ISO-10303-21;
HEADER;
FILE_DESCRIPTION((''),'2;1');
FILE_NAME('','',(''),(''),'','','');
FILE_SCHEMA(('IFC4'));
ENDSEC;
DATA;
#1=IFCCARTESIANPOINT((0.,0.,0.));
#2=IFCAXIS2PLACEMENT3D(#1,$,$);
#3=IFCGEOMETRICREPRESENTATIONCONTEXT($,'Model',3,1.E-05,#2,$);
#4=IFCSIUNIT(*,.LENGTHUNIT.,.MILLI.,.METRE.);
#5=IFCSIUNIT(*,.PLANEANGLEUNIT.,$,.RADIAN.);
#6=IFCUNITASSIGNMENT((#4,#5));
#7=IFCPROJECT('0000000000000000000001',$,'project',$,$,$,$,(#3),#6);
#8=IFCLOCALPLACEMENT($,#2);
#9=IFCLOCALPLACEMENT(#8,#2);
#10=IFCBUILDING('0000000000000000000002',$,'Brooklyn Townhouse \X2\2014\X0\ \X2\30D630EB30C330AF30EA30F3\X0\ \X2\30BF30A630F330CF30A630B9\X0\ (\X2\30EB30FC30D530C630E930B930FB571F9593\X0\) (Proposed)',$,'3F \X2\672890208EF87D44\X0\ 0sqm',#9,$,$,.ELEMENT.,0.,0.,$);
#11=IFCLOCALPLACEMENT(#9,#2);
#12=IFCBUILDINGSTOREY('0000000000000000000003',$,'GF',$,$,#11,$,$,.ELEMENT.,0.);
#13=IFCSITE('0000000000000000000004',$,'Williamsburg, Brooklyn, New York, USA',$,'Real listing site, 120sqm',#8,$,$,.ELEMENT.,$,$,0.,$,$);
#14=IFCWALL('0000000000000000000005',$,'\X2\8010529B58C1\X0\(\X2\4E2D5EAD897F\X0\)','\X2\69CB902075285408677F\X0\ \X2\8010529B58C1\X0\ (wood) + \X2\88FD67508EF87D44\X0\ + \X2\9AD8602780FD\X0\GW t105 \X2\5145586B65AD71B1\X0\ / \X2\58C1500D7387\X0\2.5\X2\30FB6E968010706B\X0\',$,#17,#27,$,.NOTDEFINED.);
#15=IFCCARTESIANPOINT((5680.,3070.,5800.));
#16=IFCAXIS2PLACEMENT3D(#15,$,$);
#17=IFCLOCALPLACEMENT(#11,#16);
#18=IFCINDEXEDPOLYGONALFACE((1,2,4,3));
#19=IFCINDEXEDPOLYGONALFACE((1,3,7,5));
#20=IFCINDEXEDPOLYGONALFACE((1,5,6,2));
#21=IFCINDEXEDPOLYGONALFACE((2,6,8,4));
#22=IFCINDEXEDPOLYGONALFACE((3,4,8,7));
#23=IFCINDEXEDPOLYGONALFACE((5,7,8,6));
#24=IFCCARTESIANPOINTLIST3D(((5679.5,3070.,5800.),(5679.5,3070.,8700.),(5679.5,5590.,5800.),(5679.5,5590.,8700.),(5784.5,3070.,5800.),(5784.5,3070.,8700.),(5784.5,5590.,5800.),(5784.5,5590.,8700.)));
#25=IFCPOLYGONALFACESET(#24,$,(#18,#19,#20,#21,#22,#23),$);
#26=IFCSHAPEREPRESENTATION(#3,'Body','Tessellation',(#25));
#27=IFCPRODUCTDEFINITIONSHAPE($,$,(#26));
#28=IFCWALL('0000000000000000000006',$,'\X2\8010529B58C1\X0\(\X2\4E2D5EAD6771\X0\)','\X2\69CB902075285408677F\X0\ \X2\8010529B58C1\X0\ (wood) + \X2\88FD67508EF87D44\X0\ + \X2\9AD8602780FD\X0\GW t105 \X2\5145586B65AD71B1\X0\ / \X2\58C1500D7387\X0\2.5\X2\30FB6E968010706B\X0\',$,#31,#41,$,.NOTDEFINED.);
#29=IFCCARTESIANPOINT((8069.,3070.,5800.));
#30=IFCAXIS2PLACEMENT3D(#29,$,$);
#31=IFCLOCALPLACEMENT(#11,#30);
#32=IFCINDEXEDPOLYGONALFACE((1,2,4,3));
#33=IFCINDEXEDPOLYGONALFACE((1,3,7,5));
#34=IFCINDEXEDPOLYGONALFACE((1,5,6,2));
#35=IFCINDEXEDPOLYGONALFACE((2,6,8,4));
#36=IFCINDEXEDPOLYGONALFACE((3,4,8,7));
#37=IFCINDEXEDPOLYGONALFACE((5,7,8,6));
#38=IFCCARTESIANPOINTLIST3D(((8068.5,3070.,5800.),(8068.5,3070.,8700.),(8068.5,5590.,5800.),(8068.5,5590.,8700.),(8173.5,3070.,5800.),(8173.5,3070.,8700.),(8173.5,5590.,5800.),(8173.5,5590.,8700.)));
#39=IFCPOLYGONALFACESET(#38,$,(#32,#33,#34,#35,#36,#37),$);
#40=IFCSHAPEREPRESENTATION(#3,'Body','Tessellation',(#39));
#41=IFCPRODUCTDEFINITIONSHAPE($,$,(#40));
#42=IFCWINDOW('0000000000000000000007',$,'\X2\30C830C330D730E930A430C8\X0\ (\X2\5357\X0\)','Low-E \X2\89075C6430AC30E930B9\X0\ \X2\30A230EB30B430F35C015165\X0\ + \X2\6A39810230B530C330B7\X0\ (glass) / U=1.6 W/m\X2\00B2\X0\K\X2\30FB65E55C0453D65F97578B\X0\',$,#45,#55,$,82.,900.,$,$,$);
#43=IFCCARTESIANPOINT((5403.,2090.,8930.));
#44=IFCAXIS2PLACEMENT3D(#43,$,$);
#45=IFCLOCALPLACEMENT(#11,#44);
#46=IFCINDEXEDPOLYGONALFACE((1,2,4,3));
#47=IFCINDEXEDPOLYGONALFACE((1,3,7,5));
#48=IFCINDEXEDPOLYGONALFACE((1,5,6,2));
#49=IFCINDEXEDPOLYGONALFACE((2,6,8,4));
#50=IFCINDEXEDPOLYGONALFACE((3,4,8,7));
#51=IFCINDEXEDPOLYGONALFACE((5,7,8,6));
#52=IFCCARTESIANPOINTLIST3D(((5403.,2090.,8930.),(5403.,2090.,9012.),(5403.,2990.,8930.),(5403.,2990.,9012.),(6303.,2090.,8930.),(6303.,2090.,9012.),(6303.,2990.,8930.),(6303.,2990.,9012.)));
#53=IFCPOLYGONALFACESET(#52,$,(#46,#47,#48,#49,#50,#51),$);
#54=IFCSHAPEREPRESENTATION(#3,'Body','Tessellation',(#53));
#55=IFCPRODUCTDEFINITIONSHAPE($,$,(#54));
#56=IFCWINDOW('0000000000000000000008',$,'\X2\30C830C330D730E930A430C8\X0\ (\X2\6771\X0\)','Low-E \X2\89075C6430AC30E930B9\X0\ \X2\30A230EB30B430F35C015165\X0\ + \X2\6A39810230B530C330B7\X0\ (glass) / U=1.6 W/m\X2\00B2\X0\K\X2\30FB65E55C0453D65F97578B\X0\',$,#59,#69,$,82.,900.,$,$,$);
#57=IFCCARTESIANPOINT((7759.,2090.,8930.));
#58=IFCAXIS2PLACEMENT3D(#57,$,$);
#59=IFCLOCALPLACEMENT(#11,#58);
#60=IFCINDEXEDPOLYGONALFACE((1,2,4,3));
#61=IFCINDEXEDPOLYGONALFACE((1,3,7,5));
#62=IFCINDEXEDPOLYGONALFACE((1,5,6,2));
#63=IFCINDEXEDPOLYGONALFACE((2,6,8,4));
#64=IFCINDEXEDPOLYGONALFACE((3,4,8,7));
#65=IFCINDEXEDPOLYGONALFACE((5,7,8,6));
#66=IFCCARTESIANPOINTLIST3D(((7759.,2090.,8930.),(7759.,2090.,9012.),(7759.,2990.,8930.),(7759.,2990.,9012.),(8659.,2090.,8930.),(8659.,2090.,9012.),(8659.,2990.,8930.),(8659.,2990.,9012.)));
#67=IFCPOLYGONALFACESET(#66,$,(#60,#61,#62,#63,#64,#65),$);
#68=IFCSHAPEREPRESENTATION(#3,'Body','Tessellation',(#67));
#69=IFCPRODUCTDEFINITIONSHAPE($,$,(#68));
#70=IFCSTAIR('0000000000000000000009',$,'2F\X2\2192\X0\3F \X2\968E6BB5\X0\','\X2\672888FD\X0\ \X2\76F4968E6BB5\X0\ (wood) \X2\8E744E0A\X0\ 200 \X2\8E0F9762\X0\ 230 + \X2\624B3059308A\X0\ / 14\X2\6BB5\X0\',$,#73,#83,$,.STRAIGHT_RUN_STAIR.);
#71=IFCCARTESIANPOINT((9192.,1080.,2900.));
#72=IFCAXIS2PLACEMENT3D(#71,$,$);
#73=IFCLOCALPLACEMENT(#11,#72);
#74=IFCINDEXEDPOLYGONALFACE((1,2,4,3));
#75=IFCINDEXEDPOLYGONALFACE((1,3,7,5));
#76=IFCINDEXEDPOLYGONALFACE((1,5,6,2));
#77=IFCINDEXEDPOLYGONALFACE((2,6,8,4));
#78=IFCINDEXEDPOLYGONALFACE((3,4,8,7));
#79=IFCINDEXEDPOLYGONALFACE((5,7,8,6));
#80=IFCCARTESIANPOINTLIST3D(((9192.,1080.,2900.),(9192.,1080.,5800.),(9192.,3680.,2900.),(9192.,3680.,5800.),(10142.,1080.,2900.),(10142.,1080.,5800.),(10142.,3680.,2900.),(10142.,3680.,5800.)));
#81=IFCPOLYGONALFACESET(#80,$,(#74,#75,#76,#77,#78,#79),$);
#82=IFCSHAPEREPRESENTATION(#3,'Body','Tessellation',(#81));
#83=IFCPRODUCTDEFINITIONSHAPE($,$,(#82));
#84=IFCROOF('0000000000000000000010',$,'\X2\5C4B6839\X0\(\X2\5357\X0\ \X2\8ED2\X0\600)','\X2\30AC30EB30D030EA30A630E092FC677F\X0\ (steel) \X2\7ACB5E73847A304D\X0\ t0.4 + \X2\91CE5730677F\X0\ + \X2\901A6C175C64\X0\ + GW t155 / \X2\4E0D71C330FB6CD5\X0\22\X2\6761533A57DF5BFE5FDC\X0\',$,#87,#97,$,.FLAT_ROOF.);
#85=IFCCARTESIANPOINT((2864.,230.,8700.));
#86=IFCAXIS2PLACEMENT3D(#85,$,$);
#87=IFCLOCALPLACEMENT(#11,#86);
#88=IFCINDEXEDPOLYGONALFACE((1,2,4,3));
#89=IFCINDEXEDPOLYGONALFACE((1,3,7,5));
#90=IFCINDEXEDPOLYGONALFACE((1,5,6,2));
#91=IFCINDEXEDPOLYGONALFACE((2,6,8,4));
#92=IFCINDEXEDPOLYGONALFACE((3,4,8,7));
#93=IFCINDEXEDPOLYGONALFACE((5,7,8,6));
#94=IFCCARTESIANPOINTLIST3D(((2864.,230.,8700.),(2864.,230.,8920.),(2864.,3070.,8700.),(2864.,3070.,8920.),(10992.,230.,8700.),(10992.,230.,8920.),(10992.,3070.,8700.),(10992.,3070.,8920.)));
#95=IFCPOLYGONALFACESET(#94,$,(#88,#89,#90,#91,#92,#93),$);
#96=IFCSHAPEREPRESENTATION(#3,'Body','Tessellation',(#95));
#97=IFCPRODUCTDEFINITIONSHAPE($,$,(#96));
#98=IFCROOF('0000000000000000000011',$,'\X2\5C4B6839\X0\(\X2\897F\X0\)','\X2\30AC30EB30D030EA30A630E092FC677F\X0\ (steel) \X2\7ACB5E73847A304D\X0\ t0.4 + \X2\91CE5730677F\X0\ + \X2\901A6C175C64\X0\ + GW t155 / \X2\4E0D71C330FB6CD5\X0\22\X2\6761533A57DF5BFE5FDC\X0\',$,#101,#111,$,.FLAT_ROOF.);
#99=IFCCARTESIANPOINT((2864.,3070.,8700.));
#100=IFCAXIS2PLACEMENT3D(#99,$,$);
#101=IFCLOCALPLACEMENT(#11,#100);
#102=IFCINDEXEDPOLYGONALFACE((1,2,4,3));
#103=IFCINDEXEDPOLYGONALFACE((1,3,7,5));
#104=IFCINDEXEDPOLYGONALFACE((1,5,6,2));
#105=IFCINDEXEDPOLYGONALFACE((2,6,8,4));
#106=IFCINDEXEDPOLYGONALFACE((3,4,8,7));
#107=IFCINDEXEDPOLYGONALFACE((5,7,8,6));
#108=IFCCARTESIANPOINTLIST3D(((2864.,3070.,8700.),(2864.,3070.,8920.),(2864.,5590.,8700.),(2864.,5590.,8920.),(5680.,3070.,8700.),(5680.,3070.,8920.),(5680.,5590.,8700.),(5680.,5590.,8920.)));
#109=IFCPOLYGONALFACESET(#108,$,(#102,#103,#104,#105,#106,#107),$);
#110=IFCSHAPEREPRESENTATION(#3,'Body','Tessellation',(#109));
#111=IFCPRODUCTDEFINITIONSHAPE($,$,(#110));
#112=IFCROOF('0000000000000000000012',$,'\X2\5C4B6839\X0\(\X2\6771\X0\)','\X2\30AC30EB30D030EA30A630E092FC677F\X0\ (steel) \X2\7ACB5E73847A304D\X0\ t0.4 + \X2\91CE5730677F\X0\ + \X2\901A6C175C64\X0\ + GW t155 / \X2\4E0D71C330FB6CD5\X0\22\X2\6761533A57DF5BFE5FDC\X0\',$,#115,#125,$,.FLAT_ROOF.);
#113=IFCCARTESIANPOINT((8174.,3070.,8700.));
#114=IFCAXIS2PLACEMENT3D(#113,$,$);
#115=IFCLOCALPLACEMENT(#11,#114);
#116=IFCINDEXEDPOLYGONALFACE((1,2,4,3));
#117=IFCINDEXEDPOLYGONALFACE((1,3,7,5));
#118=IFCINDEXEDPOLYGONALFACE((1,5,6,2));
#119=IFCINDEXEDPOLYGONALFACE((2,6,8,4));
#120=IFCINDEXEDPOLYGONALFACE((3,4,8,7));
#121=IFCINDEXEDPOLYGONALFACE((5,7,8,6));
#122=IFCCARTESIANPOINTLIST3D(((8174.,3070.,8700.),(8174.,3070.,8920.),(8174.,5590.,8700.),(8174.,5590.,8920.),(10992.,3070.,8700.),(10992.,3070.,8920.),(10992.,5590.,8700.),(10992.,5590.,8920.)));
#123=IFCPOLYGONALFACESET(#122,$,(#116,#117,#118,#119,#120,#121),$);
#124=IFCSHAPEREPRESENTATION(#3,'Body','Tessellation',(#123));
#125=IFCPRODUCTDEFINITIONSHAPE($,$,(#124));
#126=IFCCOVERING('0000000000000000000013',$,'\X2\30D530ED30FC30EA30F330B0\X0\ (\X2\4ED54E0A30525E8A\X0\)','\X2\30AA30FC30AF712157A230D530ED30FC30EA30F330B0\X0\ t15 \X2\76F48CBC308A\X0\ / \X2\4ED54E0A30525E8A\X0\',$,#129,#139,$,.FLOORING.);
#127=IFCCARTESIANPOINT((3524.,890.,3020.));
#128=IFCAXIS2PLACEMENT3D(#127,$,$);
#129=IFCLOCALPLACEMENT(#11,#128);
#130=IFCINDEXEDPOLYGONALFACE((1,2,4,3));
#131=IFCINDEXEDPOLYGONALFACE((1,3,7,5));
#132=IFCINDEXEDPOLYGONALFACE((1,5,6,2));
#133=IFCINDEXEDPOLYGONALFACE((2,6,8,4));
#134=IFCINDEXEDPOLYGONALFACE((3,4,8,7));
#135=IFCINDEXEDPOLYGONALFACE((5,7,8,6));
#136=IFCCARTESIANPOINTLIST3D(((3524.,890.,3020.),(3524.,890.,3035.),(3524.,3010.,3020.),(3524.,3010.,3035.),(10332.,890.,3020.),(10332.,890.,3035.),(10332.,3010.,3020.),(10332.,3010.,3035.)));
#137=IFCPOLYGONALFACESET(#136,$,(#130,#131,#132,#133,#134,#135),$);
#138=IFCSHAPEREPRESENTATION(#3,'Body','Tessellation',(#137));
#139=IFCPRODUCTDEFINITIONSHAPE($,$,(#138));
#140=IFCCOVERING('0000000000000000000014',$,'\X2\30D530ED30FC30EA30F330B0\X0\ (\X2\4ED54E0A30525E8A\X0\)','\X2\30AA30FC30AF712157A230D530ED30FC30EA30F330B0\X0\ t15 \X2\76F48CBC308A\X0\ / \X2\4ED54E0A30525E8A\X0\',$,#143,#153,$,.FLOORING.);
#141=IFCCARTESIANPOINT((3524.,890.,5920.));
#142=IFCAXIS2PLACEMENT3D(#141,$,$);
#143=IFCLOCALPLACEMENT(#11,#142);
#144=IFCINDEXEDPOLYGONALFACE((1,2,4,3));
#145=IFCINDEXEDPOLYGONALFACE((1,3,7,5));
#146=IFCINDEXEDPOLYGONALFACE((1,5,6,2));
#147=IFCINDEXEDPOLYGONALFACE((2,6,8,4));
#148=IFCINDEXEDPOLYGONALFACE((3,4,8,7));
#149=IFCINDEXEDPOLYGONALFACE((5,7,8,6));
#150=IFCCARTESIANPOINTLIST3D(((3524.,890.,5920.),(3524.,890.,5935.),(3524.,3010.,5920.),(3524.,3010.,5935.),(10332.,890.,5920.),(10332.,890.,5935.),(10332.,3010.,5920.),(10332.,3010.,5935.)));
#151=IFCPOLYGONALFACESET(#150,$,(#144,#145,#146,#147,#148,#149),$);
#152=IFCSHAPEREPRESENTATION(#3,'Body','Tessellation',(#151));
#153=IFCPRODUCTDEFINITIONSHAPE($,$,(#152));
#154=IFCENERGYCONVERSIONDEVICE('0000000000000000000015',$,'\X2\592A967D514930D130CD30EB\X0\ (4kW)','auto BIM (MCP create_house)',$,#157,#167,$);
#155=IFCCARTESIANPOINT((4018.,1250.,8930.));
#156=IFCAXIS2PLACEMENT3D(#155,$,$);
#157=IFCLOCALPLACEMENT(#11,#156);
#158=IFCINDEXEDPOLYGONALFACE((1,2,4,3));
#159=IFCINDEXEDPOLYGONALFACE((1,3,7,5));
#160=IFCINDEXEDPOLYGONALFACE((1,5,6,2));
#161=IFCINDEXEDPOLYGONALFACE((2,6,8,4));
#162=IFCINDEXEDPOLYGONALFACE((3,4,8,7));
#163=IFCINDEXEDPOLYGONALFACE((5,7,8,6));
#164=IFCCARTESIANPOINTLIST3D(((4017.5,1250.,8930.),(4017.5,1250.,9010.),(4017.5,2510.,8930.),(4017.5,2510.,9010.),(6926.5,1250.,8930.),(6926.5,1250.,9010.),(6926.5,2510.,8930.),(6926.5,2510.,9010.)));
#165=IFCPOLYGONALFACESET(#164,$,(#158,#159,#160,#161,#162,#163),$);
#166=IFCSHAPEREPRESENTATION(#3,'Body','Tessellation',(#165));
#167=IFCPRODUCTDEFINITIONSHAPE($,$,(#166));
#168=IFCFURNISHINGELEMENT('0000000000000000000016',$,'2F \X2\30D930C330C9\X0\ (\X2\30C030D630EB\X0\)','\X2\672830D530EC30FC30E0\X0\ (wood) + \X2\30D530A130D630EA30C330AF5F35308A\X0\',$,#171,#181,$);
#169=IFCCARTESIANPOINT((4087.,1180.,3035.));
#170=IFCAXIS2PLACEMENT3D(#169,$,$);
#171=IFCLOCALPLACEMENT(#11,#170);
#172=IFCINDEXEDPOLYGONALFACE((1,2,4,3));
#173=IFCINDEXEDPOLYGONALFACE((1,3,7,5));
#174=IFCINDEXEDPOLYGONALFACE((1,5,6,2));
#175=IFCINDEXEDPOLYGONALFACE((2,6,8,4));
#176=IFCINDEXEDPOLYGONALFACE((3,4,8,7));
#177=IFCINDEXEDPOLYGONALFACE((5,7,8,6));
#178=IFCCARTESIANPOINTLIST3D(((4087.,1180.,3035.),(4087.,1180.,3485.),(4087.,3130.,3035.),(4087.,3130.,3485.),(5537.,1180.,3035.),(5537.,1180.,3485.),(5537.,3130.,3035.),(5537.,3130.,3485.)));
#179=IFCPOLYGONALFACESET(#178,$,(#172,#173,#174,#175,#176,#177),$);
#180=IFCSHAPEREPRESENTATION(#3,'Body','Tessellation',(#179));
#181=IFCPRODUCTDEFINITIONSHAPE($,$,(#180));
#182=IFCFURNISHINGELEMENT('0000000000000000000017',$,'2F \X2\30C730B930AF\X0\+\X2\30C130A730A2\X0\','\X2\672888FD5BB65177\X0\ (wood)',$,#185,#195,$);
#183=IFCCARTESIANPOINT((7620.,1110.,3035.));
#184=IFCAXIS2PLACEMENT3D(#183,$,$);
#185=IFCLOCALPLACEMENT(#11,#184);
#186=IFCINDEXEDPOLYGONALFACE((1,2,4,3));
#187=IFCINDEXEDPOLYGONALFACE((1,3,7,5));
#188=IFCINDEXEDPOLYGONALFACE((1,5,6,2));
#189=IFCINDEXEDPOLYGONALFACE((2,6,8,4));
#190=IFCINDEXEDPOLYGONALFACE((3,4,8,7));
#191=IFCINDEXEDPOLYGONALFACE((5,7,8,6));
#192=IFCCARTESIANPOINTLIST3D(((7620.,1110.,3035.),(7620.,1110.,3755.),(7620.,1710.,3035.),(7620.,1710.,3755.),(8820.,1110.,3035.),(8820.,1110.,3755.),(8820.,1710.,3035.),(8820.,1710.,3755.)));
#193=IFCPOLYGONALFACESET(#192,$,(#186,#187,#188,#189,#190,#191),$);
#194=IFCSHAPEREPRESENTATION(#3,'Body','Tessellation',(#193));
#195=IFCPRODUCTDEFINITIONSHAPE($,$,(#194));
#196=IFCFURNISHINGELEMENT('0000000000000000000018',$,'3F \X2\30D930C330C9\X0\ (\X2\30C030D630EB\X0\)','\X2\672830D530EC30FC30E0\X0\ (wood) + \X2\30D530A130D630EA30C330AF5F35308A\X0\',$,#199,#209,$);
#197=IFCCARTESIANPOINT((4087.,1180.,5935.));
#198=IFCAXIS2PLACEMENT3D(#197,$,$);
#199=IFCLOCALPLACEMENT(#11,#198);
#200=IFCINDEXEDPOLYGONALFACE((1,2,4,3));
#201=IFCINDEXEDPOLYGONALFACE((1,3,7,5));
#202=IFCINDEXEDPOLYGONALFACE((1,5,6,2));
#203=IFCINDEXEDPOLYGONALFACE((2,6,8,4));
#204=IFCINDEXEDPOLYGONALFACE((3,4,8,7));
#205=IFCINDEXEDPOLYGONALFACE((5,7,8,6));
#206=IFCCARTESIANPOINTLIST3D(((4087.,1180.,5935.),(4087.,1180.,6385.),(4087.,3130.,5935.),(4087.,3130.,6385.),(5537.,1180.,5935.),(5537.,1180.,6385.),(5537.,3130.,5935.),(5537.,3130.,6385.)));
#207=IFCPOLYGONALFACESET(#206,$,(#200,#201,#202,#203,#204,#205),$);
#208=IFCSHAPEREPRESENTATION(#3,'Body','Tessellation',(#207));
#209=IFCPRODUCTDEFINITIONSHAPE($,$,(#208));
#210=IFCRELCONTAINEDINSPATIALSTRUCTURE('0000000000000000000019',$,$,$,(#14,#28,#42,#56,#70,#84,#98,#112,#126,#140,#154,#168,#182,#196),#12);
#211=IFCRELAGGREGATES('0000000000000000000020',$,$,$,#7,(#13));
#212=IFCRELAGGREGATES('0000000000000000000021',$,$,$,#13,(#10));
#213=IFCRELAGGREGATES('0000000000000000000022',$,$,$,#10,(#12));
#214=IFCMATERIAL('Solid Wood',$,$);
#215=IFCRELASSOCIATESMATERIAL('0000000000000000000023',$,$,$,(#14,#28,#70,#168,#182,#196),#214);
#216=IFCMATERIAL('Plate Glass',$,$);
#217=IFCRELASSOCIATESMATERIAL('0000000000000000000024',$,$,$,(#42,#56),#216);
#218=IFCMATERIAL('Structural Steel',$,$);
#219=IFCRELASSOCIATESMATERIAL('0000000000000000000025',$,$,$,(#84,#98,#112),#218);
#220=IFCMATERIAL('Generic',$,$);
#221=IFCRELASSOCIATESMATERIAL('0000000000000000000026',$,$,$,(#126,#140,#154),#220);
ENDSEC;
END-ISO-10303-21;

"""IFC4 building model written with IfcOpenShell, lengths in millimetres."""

from ifc_helpers import new_model, si_unit, frame, frame_2d, origin, place, context, project, spatial, rectangle, extrude, material, element, save


model = new_model("IFC4")

# Units and contexts
model_context = context("Model", 3, precision=1e-05, world=origin())
ifc_project = project(units=[si_unit("LENGTHUNIT", "METRE", prefix="MILLI"), si_unit("PLANEANGLEUNIT", "RADIAN")], contexts=[model_context])

# Site, building, storey
site_placement = place(None, origin())
site = spatial("IfcSite", under=ifc_project, at=site_placement, Name="Williamsburg, Brooklyn, New York, USA", ObjectType="Real listing site, 120sqm", CompositionType="ELEMENT", RefElevation=0.0)
building_placement = place(site_placement, origin())
building = spatial("IfcBuilding", under=site, at=building_placement, Name="Brooklyn Townhouse — ブルックリン タウンハウス (ルーフテラス・土間) (Proposed)", ObjectType="3F 木造軸組 0sqm", CompositionType="ELEMENT", ElevationOfRefHeight=0.0, ElevationOfTerrain=0.0)
storey_placement = place(building_placement, origin())
storey = spatial("IfcBuildingStorey", under=building, at=storey_placement, Name="GF", CompositionType="ELEMENT", Elevation=0.0)

# Shared definitions
ifc_material_1 = material(Name="Solid Wood")

# Shared definitions
ifc_material_2 = material(Name="Plate Glass")

# Walls
wall_1_placement = place(storey_placement, frame((5680.0, 3070.0, 5800.0)))
element("IfcWall", 1, at=wall_1_placement, inside=storey, material=ifc_material_1, Name="耐力壁(中庭西)", Description="構造用合板 耐力壁 (wood) + 製材軸組 + 高性能GW t105 充填断熱 / 壁倍率2.5・準耐火", PredefinedType="NOTDEFINED", context=model_context, shape_type="SweptSolid", body=[
    extrude(rectangle(XDim=105.0, YDim=2520.0, at=frame_2d((52.0, 1260.0))), frame((5680.0, 3070.0, 5800.0)), (0.0, 0.0, 1.0), 2900.0),
])
wall_2_placement = place(storey_placement, frame((8069.0, 3070.0, 5800.0)))
element("IfcWall", 2, at=wall_2_placement, inside=storey, material=ifc_material_1, Name="耐力壁(中庭東)", Description="構造用合板 耐力壁 (wood) + 製材軸組 + 高性能GW t105 充填断熱 / 壁倍率2.5・準耐火", PredefinedType="NOTDEFINED", context=model_context, shape_type="SweptSolid", body=[
    extrude(rectangle(XDim=105.0, YDim=2520.0, at=frame_2d((52.0, 1260.0))), frame((8069.0, 3070.0, 5800.0)), (0.0, 0.0, 1.0), 2900.0),
])

# Windows
window_1_placement = place(storey_placement, frame((5403.0, 2090.0, 8930.0)))
element("IfcWindow", 3, at=window_1_placement, inside=storey, material=ifc_material_2, Name="トップライト (南)", Description="Low-E 複層ガラス アルゴン封入 + 樹脂サッシ (glass) / U=1.6 W/m²K・日射取得型", OverallHeight=82.0, OverallWidth=900.0, context=model_context, shape_type="SweptSolid", body=[
    extrude(rectangle(XDim=900.0, YDim=900.0, at=frame_2d((450.0, 450.0))), frame((5403.0, 2090.0, 8930.0)), (0.0, 0.0, 1.0), 82.0),
])
window_2_placement = place(storey_placement, frame((7759.0, 2090.0, 8930.0)))
element("IfcWindow", 4, at=window_2_placement, inside=storey, material=ifc_material_2, Name="トップライト (東)", Description="Low-E 複層ガラス アルゴン封入 + 樹脂サッシ (glass) / U=1.6 W/m²K・日射取得型", OverallHeight=82.0, OverallWidth=900.0, context=model_context, shape_type="SweptSolid", body=[
    extrude(rectangle(XDim=900.0, YDim=900.0, at=frame_2d((450.0, 450.0))), frame((7759.0, 2090.0, 8930.0)), (0.0, 0.0, 1.0), 82.0),
])

# Stair
stair_placement = place(storey_placement, frame((9192.0, 1080.0, 2900.0)))
element("IfcStair", 5, at=stair_placement, inside=storey, material=ifc_material_1, Name="2F→3F 階段", Description="木製 直階段 (wood) 蹴上 200 踏面 230 + 手すり / 14段", PredefinedType="STRAIGHT_RUN_STAIR", context=model_context, shape_type="SweptSolid", body=[
    extrude(rectangle(XDim=950.0, YDim=2600.0, at=frame_2d((475.0, 1300.0))), frame((9192.0, 1080.0, 2900.0)), (0.0, 0.0, 1.0), 2900.0),
])

# Roofs
ifc_material_3 = material(Name="Structural Steel")
roof_1_placement = place(storey_placement, frame((2864.0, 230.0, 8700.0)))
element("IfcRoof", 6, at=roof_1_placement, inside=storey, material=ifc_material_3, Name="屋根(南 軒600)", Description="ガルバリウム鋼板 (steel) 立平葺き t0.4 + 野地板 + 通気層 + GW t155 / 不燃・法22条区域対応", PredefinedType="FLAT_ROOF", context=model_context, shape_type="SweptSolid", body=[
    extrude(rectangle(XDim=8128.0, YDim=2840.0, at=frame_2d((4064.0, 1420.0))), frame((2864.0, 230.0, 8700.0)), (0.0, 0.0, 1.0), 220.0),
])
roof_2_placement = place(storey_placement, frame((2864.0, 3070.0, 8700.0)))
element("IfcRoof", 7, at=roof_2_placement, inside=storey, material=ifc_material_3, Name="屋根(西)", Description="ガルバリウム鋼板 (steel) 立平葺き t0.4 + 野地板 + 通気層 + GW t155 / 不燃・法22条区域対応", PredefinedType="FLAT_ROOF", context=model_context, shape_type="SweptSolid", body=[
    extrude(rectangle(XDim=2816.0, YDim=2520.0, at=frame_2d((1408.0, 1260.0))), frame((2864.0, 3070.0, 8700.0)), (0.0, 0.0, 1.0), 220.0),
])
roof_3_placement = place(storey_placement, frame((8174.0, 3070.0, 8700.0)))
element("IfcRoof", 8, at=roof_3_placement, inside=storey, material=ifc_material_3, Name="屋根(東)", Description="ガルバリウム鋼板 (steel) 立平葺き t0.4 + 野地板 + 通気層 + GW t155 / 不燃・法22条区域対応", PredefinedType="FLAT_ROOF", context=model_context, shape_type="SweptSolid", body=[
    extrude(rectangle(XDim=2818.0, YDim=2520.0, at=frame_2d((1409.0, 1260.0))), frame((8174.0, 3070.0, 8700.0)), (0.0, 0.0, 1.0), 220.0),
])

# Coverings
ifc_material_4 = material(Name="Generic")
covering_1_placement = place(storey_placement, frame((3524.0, 890.0, 3020.0)))
element("IfcCovering", 9, at=covering_1_placement, inside=storey, material=ifc_material_4, Name="フローリング (仕上げ床)", Description="オーク無垢フローリング t15 直貼り / 仕上げ床", PredefinedType="FLOORING", context=model_context, shape_type="SweptSolid", body=[
    extrude(rectangle(XDim=6808.0, YDim=2120.0, at=frame_2d((3404.0, 1060.0))), frame((3524.0, 890.0, 3020.0)), (0.0, 0.0, 1.0), 15.0),
])
covering_2_placement = place(storey_placement, frame((3524.0, 890.0, 5920.0)))
element("IfcCovering", 10, at=covering_2_placement, inside=storey, material=ifc_material_4, Name="フローリング (仕上げ床)", Description="オーク無垢フローリング t15 直貼り / 仕上げ床", PredefinedType="FLOORING", context=model_context, shape_type="SweptSolid", body=[
    extrude(rectangle(XDim=6808.0, YDim=2120.0, at=frame_2d((3404.0, 1060.0))), frame((3524.0, 890.0, 5920.0)), (0.0, 0.0, 1.0), 15.0),
])

# Energy conversion device
energy_conversion_device_placement = place(storey_placement, frame((4018.0, 1250.0, 8930.0)))
element("IfcEnergyConversionDevice", 11, at=energy_conversion_device_placement, inside=storey, material=ifc_material_4, Name="太陽光パネル (4kW)", Description="auto BIM (MCP create_house)", context=model_context, shape_type="SweptSolid", body=[
    extrude(rectangle(XDim=2909.0, YDim=1260.0, at=frame_2d((1454.0, 630.0))), frame((4018.0, 1250.0, 8930.0)), (0.0, 0.0, 1.0), 80.0),
])

# Furnishing elements
furnishing_1_placement = place(storey_placement, frame((4087.0, 1180.0, 3035.0)))
element("IfcFurnishingElement", 12, at=furnishing_1_placement, inside=storey, material=ifc_material_1, Name="2F ベッド (ダブル)", Description="木フレーム (wood) + ファブリック張り", context=model_context, shape_type="SweptSolid", body=[
    extrude(rectangle(XDim=1450.0, YDim=1950.0, at=frame_2d((725.0, 975.0))), frame((4087.0, 1180.0, 3035.0)), (0.0, 0.0, 1.0), 450.0),
])
furnishing_2_placement = place(storey_placement, frame((7620.0, 1110.0, 3035.0)))
element("IfcFurnishingElement", 13, at=furnishing_2_placement, inside=storey, material=ifc_material_1, Name="2F デスク+チェア", Description="木製家具 (wood)", context=model_context, shape_type="SweptSolid", body=[
    extrude(rectangle(XDim=1200.0, YDim=600.0, at=frame_2d((600.0, 300.0))), frame((7620.0, 1110.0, 3035.0)), (0.0, 0.0, 1.0), 720.0),
])
furnishing_3_placement = place(storey_placement, frame((4087.0, 1180.0, 5935.0)))
element("IfcFurnishingElement", 14, at=furnishing_3_placement, inside=storey, material=ifc_material_1, Name="3F ベッド (ダブル)", Description="木フレーム (wood) + ファブリック張り", context=model_context, shape_type="SweptSolid", body=[
    extrude(rectangle(XDim=1450.0, YDim=1950.0, at=frame_2d((725.0, 975.0))), frame((4087.0, 1180.0, 5935.0)), (0.0, 0.0, 1.0), 450.0),
])

save(model, "model.ifc")
